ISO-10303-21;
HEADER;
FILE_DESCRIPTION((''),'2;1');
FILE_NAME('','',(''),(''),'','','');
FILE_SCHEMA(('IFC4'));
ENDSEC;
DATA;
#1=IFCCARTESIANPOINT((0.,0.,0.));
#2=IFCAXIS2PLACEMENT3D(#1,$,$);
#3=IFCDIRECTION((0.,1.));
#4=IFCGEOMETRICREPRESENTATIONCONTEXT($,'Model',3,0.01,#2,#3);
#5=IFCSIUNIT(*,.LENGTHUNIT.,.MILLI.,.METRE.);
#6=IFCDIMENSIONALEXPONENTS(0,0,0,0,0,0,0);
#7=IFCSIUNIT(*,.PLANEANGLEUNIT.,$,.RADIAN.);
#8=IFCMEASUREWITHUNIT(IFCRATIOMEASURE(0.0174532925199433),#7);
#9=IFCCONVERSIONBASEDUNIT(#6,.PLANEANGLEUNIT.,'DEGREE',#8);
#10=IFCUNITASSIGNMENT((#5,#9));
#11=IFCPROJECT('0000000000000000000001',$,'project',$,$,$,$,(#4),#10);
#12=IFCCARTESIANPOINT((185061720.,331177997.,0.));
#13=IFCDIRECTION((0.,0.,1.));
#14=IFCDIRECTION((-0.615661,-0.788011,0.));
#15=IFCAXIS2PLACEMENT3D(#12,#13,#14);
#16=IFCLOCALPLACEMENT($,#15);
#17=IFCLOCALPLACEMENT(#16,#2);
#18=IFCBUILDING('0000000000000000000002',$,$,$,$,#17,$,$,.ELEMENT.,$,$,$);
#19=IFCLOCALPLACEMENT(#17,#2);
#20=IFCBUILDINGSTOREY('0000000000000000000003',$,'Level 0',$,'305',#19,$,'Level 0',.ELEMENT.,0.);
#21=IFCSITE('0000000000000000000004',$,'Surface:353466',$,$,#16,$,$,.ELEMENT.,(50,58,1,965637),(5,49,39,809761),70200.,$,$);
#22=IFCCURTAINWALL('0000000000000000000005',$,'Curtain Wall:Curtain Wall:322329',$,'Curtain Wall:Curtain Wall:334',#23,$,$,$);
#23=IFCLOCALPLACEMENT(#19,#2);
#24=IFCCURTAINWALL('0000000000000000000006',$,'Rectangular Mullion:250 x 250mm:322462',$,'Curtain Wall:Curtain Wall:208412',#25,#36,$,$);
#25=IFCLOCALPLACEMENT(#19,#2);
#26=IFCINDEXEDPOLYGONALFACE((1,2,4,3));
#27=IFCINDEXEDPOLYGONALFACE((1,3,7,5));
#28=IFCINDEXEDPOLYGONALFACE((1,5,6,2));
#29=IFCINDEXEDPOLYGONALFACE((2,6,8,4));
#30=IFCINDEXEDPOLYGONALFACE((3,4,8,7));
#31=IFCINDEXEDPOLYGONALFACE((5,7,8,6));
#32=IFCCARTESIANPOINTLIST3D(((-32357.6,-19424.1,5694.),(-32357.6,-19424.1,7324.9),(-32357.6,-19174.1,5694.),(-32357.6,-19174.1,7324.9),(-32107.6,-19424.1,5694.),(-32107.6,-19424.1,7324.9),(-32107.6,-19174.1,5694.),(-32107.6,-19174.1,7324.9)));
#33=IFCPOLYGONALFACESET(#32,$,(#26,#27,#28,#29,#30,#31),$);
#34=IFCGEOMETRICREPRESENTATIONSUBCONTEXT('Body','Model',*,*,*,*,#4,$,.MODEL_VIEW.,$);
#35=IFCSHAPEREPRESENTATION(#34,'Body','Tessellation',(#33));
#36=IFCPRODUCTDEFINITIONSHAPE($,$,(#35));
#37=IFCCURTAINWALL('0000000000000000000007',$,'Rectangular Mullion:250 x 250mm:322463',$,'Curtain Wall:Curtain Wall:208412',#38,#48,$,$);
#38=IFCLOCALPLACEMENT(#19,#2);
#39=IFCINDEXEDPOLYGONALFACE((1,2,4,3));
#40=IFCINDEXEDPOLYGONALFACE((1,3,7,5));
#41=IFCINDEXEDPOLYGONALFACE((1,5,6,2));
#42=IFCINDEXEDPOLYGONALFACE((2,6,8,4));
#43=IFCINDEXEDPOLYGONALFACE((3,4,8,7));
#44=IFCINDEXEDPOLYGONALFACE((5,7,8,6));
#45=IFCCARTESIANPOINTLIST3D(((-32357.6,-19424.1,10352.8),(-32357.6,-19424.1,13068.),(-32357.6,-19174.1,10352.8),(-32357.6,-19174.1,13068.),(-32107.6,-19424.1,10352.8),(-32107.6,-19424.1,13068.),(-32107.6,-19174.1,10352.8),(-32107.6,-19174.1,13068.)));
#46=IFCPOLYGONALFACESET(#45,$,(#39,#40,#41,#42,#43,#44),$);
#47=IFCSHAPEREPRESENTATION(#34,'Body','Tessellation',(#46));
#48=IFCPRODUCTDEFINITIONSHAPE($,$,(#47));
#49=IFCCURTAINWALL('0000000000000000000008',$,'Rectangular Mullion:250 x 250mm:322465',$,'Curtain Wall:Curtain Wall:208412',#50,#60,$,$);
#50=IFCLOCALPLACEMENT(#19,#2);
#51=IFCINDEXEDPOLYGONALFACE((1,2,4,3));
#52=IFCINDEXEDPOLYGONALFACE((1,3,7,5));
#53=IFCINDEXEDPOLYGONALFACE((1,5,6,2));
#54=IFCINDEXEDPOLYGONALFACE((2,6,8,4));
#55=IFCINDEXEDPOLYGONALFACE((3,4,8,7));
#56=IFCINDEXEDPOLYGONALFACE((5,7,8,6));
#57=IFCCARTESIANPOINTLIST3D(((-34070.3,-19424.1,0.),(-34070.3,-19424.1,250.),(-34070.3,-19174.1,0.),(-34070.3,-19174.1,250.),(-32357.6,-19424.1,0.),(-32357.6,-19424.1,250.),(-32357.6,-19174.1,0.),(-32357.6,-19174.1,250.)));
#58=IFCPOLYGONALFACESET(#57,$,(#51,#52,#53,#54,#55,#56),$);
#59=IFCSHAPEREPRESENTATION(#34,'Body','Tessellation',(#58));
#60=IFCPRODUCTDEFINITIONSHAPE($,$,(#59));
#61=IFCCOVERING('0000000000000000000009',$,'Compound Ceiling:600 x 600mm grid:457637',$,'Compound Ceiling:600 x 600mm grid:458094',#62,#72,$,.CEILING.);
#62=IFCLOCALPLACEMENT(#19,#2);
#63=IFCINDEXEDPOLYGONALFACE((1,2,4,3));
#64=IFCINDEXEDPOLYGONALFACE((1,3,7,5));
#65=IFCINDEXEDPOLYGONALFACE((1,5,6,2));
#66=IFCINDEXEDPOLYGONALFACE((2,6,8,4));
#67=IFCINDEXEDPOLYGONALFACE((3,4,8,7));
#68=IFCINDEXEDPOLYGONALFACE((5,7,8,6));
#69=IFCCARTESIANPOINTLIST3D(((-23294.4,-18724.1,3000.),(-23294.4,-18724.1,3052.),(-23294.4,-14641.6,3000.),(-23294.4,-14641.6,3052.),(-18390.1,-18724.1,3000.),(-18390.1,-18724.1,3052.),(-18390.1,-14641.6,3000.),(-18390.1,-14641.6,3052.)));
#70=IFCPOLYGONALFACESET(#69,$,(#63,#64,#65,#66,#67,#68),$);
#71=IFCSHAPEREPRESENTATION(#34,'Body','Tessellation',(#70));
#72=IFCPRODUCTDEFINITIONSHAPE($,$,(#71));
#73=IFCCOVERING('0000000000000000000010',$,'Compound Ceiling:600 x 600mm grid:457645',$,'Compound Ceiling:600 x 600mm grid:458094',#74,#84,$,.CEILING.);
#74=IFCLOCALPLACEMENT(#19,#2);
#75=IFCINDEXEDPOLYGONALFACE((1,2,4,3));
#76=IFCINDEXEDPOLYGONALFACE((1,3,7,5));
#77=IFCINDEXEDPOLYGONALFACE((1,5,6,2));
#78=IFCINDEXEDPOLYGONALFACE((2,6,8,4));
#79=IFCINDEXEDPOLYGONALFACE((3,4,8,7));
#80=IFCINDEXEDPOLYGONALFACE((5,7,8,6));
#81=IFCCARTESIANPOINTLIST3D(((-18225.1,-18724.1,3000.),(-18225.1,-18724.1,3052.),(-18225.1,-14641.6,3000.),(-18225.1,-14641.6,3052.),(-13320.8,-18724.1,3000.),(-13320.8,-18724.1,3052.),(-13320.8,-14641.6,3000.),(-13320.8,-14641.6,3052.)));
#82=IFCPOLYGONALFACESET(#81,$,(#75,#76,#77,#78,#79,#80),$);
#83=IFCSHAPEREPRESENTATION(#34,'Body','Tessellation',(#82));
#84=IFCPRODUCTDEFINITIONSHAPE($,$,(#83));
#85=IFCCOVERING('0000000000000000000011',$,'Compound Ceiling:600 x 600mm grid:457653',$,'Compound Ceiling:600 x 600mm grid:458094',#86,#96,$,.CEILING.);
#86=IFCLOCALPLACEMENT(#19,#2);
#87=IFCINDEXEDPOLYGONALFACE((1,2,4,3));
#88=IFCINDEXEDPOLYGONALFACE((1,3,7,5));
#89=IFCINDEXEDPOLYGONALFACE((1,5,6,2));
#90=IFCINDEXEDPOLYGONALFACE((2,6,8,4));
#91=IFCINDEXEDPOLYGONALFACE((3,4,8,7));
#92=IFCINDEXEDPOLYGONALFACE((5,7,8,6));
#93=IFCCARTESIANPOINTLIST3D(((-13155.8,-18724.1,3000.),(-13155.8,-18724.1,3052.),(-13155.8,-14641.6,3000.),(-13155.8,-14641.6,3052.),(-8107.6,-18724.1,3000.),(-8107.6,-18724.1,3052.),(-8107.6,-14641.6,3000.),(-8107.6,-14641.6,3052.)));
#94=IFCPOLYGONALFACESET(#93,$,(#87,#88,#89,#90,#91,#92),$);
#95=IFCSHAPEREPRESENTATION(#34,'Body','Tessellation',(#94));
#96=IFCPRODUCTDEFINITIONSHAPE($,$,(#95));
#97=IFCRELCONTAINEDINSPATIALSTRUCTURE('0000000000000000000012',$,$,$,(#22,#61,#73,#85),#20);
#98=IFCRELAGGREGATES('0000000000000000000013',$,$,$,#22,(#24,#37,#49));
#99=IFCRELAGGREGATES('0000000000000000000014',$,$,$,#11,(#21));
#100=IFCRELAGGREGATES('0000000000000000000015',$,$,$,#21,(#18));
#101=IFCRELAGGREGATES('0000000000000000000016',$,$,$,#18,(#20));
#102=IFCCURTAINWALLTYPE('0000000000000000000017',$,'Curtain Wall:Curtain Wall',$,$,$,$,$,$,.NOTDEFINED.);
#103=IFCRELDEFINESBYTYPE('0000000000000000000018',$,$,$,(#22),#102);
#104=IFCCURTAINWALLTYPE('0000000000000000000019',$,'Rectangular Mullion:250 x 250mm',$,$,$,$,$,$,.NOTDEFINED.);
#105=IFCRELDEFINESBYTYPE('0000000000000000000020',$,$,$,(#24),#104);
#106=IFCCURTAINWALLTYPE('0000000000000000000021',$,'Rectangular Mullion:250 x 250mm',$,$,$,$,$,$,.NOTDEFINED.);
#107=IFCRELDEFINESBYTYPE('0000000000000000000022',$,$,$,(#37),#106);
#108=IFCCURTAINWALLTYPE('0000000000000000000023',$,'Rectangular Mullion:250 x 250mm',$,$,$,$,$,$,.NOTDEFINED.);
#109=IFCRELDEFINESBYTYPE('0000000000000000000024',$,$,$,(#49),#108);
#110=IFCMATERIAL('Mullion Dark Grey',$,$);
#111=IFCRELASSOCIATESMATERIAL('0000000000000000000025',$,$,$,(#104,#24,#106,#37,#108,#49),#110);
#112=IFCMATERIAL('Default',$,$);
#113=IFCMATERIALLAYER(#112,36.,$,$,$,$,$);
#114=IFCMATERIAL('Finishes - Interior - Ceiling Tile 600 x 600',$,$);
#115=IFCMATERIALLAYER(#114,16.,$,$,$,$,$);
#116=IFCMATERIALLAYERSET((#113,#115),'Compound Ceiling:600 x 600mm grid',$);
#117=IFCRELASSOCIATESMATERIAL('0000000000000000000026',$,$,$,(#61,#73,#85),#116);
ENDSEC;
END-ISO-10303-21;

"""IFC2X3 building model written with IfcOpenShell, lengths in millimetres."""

from ifc_helpers import new_model, entity, si_unit, converted_unit, direction, frame, frame_2d, origin, origin_2d_with_axis, place, context, subcontext, project, spatial, rectangle, extrude, source, transform, mapped, material, layer, layer_set, layer_usage, type_object, type_shapes, element, aggregate, save


model = new_model("IFC2X3")

# Units and contexts
model_context = context("Model", 3, precision=0.01, world=origin(), true_north=direction((0.0, 1.0)))
body_context = subcontext(model_context, "Body", "Model", "MODEL_VIEW")
ifc_project = project(units=[si_unit("LENGTHUNIT", "METRE", prefix="MILLI"), converted_unit("PLANEANGLEUNIT", "DEGREE", entity("IfcRatioMeasure", 0.0174532925199433), si_unit("PLANEANGLEUNIT", "RADIAN"), dimensions=[0, 0, 0, 0, 0, 0, 0])], contexts=[model_context])

# Site, building, storey
site_placement = place(None, frame((185061720.0, 331177997.0, 0.0), z_axis=(0.0, 0.0, 1.0), x_axis=(-0.615661, -0.788011, 0.0)))
site = spatial("IfcSite", under=ifc_project, at=site_placement, Name="Surface:353466", CompositionType="ELEMENT", RefLatitude=(50, 58, 1, 965637), RefLongitude=(5, 49, 39, 809761), RefElevation=70200.0)
building_placement = place(site_placement, origin())
building = spatial("IfcBuilding", under=site, at=building_placement, CompositionType="ELEMENT")
storey_placement = place(building_placement, origin())
storey = spatial("IfcBuildingStorey", under=building, at=storey_placement, Name="Level 0", ObjectType="305", LongName="Level 0", CompositionType="ELEMENT", Elevation=0.0)

# Curtain walls
curtain_wall_type_1 = type_object("IfcCurtainWallType", Name="Curtain Wall:Curtain Wall", PredefinedType="NOTDEFINED")
curtain_wall_1_placement = place(storey_placement, origin())
curtain_wall_1 = element("IfcCurtainWall", 1, at=curtain_wall_1_placement, inside=storey, type_object=curtain_wall_type_1, Name="Curtain Wall:Curtain Wall:322329", ObjectType="Curtain Wall:Curtain Wall:334")
ifc_material_1 = material(Name="Mullion Dark Grey")
curtain_wall_type_2 = type_object("IfcCurtainWallType", Name="Rectangular Mullion:250 x 250mm", PredefinedType="NOTDEFINED", material=ifc_material_1)
shared_shape_1 = source(origin(), body_context, "Body", "SweptSolid", [
    extrude(rectangle(XDim=250.0, YDim=250.0, at=origin_2d_with_axis()), frame((-125.0, 0.0, -1630.9), z_axis=(0.0, 0.0, 1.0), x_axis=(-1.0, 0.0, 0.0)), (0.0, 0.0, 1.0), 1630.9),
])
type_shapes(curtain_wall_type_2, [shared_shape_1])
curtain_wall_2_placement = place(storey_placement, frame((-32107.6, -19299.1, 7324.9)))
curtain_wall_2 = element("IfcCurtainWall", 2, at=curtain_wall_2_placement, type_object=curtain_wall_type_2, material=ifc_material_1, Name="Rectangular Mullion:250 x 250mm:322462", ObjectType="Curtain Wall:Curtain Wall:208412", context=body_context, shape_type="MappedRepresentation", body=[
    mapped(shared_shape_1, transform((0.0, 0.0, 0.0), scale=1.0)),
])
curtain_wall_type_3 = type_object("IfcCurtainWallType", Name="Rectangular Mullion:250 x 250mm", PredefinedType="NOTDEFINED", material=ifc_material_1)
shared_shape_2 = source(origin(), body_context, "Body", "SweptSolid", [
    extrude(rectangle(XDim=250.0, YDim=250.0, at=origin_2d_with_axis()), frame((-125.0, 0.0, -2715.2), z_axis=(0.0, 0.0, 1.0), x_axis=(-1.0, 0.0, 0.0)), (0.0, 0.0, 1.0), 2715.2),
])
type_shapes(curtain_wall_type_3, [shared_shape_2])
curtain_wall_3_placement = place(storey_placement, frame((-32107.6, -19299.1, 13068.0)))
curtain_wall_3 = element("IfcCurtainWall", 3, at=curtain_wall_3_placement, type_object=curtain_wall_type_3, material=ifc_material_1, Name="Rectangular Mullion:250 x 250mm:322463", ObjectType="Curtain Wall:Curtain Wall:208412", context=body_context, shape_type="MappedRepresentation", body=[
    mapped(shared_shape_2, transform((0.0, 0.0, 0.0), scale=1.0)),
])
curtain_wall_type_4 = type_object("IfcCurtainWallType", Name="Rectangular Mullion:250 x 250mm", PredefinedType="NOTDEFINED", material=ifc_material_1)
shared_shape_3 = source(origin(), body_context, "Body", "SweptSolid", [
    extrude(rectangle(XDim=250.0, YDim=250.0, at=origin_2d_with_axis()), frame((-125.0, 0.0, -1712.7), z_axis=(0.0, 0.0, 1.0), x_axis=(-1.0, 0.0, 0.0)), (0.0, 0.0, 1.0), 1712.7),
])
type_shapes(curtain_wall_type_4, [shared_shape_3])
curtain_wall_4_placement = place(storey_placement, frame((-32357.6, -19299.1, 0.0), z_axis=(1.0, 0.0, 0.0), x_axis=(0.0, 0.0, -1.0)))
curtain_wall_4 = element("IfcCurtainWall", 4, at=curtain_wall_4_placement, type_object=curtain_wall_type_4, material=ifc_material_1, Name="Rectangular Mullion:250 x 250mm:322465", ObjectType="Curtain Wall:Curtain Wall:208412", context=body_context, shape_type="MappedRepresentation", body=[
    mapped(shared_shape_3, transform((0.0, 0.0, 0.0), scale=1.0)),
])
aggregate(curtain_wall_1, [curtain_wall_2, curtain_wall_3, curtain_wall_4])

# Coverings
ifc_material_2 = material(Name="Default")
ifc_layer_1 = layer(ifc_material_2, 36.0)
ifc_material_3 = material(Name="Finishes - Interior - Ceiling Tile 600 x 600")
ifc_layer_2 = layer(ifc_material_3, 16.0)
ifc_layer_set_1 = layer_set([ifc_layer_1, ifc_layer_2], Name="Compound Ceiling:600 x 600mm grid")
ifc_layer_usage_1 = layer_usage(ifc_layer_set_1, "AXIS3", "POSITIVE", 0.0)
covering_1_placement = place(storey_placement, frame((-23294.4, -18724.1, 3000.0)))
element("IfcCovering", 5, at=covering_1_placement, inside=storey, material=ifc_layer_usage_1, Name="Compound Ceiling:600 x 600mm grid:457637", ObjectType="Compound Ceiling:600 x 600mm grid:458094", PredefinedType="CEILING", context=body_context, shape_type="SweptSolid", body=[
    extrude(rectangle(XDim=4082.5, YDim=4904.3, at=frame_2d((0.0, 0.0), x_axis=(1.0, 0.0))), frame((2452.1, 2041.3, 0.0), z_axis=(0.0, 0.0, 1.0), x_axis=(0.0, 1.0, 0.0)), (0.0, 0.0, 1.0), 52.0),
])
ifc_layer_usage_2 = layer_usage(ifc_layer_set_1, "AXIS3", "POSITIVE", 0.0)
covering_2_placement = place(storey_placement, frame((-18225.1, -18724.1, 3000.0)))
element("IfcCovering", 6, at=covering_2_placement, inside=storey, material=ifc_layer_usage_2, Name="Compound Ceiling:600 x 600mm grid:457645", ObjectType="Compound Ceiling:600 x 600mm grid:458094", PredefinedType="CEILING", context=body_context, shape_type="SweptSolid", body=[
    extrude(rectangle(XDim=4082.5, YDim=4904.3, at=frame_2d((0.0, 0.0), x_axis=(1.0, 0.0))), frame((2452.1, 2041.2, 0.0), z_axis=(0.0, 0.0, 1.0), x_axis=(0.0, 1.0, 0.0)), (0.0, 0.0, 1.0), 52.0),
])
ifc_layer_usage_3 = layer_usage(ifc_layer_set_1, "AXIS3", "POSITIVE", 0.0)
covering_3_placement = place(storey_placement, frame((-13155.8, -18724.1, 3000.0)))
element("IfcCovering", 7, at=covering_3_placement, inside=storey, material=ifc_layer_usage_3, Name="Compound Ceiling:600 x 600mm grid:457653", ObjectType="Compound Ceiling:600 x 600mm grid:458094", PredefinedType="CEILING", context=body_context, shape_type="SweptSolid", body=[
    extrude(rectangle(XDim=5048.2, YDim=4082.5, at=frame_2d((0.0, 0.0), x_axis=(1.0, 0.0))), frame((2524.1, 2041.2, 0.0), z_axis=(0.0, 0.0, 1.0), x_axis=(-1.0, 0.0, 0.0)), (0.0, 0.0, 1.0), 52.0),
])

save(model, "model.ifc")
